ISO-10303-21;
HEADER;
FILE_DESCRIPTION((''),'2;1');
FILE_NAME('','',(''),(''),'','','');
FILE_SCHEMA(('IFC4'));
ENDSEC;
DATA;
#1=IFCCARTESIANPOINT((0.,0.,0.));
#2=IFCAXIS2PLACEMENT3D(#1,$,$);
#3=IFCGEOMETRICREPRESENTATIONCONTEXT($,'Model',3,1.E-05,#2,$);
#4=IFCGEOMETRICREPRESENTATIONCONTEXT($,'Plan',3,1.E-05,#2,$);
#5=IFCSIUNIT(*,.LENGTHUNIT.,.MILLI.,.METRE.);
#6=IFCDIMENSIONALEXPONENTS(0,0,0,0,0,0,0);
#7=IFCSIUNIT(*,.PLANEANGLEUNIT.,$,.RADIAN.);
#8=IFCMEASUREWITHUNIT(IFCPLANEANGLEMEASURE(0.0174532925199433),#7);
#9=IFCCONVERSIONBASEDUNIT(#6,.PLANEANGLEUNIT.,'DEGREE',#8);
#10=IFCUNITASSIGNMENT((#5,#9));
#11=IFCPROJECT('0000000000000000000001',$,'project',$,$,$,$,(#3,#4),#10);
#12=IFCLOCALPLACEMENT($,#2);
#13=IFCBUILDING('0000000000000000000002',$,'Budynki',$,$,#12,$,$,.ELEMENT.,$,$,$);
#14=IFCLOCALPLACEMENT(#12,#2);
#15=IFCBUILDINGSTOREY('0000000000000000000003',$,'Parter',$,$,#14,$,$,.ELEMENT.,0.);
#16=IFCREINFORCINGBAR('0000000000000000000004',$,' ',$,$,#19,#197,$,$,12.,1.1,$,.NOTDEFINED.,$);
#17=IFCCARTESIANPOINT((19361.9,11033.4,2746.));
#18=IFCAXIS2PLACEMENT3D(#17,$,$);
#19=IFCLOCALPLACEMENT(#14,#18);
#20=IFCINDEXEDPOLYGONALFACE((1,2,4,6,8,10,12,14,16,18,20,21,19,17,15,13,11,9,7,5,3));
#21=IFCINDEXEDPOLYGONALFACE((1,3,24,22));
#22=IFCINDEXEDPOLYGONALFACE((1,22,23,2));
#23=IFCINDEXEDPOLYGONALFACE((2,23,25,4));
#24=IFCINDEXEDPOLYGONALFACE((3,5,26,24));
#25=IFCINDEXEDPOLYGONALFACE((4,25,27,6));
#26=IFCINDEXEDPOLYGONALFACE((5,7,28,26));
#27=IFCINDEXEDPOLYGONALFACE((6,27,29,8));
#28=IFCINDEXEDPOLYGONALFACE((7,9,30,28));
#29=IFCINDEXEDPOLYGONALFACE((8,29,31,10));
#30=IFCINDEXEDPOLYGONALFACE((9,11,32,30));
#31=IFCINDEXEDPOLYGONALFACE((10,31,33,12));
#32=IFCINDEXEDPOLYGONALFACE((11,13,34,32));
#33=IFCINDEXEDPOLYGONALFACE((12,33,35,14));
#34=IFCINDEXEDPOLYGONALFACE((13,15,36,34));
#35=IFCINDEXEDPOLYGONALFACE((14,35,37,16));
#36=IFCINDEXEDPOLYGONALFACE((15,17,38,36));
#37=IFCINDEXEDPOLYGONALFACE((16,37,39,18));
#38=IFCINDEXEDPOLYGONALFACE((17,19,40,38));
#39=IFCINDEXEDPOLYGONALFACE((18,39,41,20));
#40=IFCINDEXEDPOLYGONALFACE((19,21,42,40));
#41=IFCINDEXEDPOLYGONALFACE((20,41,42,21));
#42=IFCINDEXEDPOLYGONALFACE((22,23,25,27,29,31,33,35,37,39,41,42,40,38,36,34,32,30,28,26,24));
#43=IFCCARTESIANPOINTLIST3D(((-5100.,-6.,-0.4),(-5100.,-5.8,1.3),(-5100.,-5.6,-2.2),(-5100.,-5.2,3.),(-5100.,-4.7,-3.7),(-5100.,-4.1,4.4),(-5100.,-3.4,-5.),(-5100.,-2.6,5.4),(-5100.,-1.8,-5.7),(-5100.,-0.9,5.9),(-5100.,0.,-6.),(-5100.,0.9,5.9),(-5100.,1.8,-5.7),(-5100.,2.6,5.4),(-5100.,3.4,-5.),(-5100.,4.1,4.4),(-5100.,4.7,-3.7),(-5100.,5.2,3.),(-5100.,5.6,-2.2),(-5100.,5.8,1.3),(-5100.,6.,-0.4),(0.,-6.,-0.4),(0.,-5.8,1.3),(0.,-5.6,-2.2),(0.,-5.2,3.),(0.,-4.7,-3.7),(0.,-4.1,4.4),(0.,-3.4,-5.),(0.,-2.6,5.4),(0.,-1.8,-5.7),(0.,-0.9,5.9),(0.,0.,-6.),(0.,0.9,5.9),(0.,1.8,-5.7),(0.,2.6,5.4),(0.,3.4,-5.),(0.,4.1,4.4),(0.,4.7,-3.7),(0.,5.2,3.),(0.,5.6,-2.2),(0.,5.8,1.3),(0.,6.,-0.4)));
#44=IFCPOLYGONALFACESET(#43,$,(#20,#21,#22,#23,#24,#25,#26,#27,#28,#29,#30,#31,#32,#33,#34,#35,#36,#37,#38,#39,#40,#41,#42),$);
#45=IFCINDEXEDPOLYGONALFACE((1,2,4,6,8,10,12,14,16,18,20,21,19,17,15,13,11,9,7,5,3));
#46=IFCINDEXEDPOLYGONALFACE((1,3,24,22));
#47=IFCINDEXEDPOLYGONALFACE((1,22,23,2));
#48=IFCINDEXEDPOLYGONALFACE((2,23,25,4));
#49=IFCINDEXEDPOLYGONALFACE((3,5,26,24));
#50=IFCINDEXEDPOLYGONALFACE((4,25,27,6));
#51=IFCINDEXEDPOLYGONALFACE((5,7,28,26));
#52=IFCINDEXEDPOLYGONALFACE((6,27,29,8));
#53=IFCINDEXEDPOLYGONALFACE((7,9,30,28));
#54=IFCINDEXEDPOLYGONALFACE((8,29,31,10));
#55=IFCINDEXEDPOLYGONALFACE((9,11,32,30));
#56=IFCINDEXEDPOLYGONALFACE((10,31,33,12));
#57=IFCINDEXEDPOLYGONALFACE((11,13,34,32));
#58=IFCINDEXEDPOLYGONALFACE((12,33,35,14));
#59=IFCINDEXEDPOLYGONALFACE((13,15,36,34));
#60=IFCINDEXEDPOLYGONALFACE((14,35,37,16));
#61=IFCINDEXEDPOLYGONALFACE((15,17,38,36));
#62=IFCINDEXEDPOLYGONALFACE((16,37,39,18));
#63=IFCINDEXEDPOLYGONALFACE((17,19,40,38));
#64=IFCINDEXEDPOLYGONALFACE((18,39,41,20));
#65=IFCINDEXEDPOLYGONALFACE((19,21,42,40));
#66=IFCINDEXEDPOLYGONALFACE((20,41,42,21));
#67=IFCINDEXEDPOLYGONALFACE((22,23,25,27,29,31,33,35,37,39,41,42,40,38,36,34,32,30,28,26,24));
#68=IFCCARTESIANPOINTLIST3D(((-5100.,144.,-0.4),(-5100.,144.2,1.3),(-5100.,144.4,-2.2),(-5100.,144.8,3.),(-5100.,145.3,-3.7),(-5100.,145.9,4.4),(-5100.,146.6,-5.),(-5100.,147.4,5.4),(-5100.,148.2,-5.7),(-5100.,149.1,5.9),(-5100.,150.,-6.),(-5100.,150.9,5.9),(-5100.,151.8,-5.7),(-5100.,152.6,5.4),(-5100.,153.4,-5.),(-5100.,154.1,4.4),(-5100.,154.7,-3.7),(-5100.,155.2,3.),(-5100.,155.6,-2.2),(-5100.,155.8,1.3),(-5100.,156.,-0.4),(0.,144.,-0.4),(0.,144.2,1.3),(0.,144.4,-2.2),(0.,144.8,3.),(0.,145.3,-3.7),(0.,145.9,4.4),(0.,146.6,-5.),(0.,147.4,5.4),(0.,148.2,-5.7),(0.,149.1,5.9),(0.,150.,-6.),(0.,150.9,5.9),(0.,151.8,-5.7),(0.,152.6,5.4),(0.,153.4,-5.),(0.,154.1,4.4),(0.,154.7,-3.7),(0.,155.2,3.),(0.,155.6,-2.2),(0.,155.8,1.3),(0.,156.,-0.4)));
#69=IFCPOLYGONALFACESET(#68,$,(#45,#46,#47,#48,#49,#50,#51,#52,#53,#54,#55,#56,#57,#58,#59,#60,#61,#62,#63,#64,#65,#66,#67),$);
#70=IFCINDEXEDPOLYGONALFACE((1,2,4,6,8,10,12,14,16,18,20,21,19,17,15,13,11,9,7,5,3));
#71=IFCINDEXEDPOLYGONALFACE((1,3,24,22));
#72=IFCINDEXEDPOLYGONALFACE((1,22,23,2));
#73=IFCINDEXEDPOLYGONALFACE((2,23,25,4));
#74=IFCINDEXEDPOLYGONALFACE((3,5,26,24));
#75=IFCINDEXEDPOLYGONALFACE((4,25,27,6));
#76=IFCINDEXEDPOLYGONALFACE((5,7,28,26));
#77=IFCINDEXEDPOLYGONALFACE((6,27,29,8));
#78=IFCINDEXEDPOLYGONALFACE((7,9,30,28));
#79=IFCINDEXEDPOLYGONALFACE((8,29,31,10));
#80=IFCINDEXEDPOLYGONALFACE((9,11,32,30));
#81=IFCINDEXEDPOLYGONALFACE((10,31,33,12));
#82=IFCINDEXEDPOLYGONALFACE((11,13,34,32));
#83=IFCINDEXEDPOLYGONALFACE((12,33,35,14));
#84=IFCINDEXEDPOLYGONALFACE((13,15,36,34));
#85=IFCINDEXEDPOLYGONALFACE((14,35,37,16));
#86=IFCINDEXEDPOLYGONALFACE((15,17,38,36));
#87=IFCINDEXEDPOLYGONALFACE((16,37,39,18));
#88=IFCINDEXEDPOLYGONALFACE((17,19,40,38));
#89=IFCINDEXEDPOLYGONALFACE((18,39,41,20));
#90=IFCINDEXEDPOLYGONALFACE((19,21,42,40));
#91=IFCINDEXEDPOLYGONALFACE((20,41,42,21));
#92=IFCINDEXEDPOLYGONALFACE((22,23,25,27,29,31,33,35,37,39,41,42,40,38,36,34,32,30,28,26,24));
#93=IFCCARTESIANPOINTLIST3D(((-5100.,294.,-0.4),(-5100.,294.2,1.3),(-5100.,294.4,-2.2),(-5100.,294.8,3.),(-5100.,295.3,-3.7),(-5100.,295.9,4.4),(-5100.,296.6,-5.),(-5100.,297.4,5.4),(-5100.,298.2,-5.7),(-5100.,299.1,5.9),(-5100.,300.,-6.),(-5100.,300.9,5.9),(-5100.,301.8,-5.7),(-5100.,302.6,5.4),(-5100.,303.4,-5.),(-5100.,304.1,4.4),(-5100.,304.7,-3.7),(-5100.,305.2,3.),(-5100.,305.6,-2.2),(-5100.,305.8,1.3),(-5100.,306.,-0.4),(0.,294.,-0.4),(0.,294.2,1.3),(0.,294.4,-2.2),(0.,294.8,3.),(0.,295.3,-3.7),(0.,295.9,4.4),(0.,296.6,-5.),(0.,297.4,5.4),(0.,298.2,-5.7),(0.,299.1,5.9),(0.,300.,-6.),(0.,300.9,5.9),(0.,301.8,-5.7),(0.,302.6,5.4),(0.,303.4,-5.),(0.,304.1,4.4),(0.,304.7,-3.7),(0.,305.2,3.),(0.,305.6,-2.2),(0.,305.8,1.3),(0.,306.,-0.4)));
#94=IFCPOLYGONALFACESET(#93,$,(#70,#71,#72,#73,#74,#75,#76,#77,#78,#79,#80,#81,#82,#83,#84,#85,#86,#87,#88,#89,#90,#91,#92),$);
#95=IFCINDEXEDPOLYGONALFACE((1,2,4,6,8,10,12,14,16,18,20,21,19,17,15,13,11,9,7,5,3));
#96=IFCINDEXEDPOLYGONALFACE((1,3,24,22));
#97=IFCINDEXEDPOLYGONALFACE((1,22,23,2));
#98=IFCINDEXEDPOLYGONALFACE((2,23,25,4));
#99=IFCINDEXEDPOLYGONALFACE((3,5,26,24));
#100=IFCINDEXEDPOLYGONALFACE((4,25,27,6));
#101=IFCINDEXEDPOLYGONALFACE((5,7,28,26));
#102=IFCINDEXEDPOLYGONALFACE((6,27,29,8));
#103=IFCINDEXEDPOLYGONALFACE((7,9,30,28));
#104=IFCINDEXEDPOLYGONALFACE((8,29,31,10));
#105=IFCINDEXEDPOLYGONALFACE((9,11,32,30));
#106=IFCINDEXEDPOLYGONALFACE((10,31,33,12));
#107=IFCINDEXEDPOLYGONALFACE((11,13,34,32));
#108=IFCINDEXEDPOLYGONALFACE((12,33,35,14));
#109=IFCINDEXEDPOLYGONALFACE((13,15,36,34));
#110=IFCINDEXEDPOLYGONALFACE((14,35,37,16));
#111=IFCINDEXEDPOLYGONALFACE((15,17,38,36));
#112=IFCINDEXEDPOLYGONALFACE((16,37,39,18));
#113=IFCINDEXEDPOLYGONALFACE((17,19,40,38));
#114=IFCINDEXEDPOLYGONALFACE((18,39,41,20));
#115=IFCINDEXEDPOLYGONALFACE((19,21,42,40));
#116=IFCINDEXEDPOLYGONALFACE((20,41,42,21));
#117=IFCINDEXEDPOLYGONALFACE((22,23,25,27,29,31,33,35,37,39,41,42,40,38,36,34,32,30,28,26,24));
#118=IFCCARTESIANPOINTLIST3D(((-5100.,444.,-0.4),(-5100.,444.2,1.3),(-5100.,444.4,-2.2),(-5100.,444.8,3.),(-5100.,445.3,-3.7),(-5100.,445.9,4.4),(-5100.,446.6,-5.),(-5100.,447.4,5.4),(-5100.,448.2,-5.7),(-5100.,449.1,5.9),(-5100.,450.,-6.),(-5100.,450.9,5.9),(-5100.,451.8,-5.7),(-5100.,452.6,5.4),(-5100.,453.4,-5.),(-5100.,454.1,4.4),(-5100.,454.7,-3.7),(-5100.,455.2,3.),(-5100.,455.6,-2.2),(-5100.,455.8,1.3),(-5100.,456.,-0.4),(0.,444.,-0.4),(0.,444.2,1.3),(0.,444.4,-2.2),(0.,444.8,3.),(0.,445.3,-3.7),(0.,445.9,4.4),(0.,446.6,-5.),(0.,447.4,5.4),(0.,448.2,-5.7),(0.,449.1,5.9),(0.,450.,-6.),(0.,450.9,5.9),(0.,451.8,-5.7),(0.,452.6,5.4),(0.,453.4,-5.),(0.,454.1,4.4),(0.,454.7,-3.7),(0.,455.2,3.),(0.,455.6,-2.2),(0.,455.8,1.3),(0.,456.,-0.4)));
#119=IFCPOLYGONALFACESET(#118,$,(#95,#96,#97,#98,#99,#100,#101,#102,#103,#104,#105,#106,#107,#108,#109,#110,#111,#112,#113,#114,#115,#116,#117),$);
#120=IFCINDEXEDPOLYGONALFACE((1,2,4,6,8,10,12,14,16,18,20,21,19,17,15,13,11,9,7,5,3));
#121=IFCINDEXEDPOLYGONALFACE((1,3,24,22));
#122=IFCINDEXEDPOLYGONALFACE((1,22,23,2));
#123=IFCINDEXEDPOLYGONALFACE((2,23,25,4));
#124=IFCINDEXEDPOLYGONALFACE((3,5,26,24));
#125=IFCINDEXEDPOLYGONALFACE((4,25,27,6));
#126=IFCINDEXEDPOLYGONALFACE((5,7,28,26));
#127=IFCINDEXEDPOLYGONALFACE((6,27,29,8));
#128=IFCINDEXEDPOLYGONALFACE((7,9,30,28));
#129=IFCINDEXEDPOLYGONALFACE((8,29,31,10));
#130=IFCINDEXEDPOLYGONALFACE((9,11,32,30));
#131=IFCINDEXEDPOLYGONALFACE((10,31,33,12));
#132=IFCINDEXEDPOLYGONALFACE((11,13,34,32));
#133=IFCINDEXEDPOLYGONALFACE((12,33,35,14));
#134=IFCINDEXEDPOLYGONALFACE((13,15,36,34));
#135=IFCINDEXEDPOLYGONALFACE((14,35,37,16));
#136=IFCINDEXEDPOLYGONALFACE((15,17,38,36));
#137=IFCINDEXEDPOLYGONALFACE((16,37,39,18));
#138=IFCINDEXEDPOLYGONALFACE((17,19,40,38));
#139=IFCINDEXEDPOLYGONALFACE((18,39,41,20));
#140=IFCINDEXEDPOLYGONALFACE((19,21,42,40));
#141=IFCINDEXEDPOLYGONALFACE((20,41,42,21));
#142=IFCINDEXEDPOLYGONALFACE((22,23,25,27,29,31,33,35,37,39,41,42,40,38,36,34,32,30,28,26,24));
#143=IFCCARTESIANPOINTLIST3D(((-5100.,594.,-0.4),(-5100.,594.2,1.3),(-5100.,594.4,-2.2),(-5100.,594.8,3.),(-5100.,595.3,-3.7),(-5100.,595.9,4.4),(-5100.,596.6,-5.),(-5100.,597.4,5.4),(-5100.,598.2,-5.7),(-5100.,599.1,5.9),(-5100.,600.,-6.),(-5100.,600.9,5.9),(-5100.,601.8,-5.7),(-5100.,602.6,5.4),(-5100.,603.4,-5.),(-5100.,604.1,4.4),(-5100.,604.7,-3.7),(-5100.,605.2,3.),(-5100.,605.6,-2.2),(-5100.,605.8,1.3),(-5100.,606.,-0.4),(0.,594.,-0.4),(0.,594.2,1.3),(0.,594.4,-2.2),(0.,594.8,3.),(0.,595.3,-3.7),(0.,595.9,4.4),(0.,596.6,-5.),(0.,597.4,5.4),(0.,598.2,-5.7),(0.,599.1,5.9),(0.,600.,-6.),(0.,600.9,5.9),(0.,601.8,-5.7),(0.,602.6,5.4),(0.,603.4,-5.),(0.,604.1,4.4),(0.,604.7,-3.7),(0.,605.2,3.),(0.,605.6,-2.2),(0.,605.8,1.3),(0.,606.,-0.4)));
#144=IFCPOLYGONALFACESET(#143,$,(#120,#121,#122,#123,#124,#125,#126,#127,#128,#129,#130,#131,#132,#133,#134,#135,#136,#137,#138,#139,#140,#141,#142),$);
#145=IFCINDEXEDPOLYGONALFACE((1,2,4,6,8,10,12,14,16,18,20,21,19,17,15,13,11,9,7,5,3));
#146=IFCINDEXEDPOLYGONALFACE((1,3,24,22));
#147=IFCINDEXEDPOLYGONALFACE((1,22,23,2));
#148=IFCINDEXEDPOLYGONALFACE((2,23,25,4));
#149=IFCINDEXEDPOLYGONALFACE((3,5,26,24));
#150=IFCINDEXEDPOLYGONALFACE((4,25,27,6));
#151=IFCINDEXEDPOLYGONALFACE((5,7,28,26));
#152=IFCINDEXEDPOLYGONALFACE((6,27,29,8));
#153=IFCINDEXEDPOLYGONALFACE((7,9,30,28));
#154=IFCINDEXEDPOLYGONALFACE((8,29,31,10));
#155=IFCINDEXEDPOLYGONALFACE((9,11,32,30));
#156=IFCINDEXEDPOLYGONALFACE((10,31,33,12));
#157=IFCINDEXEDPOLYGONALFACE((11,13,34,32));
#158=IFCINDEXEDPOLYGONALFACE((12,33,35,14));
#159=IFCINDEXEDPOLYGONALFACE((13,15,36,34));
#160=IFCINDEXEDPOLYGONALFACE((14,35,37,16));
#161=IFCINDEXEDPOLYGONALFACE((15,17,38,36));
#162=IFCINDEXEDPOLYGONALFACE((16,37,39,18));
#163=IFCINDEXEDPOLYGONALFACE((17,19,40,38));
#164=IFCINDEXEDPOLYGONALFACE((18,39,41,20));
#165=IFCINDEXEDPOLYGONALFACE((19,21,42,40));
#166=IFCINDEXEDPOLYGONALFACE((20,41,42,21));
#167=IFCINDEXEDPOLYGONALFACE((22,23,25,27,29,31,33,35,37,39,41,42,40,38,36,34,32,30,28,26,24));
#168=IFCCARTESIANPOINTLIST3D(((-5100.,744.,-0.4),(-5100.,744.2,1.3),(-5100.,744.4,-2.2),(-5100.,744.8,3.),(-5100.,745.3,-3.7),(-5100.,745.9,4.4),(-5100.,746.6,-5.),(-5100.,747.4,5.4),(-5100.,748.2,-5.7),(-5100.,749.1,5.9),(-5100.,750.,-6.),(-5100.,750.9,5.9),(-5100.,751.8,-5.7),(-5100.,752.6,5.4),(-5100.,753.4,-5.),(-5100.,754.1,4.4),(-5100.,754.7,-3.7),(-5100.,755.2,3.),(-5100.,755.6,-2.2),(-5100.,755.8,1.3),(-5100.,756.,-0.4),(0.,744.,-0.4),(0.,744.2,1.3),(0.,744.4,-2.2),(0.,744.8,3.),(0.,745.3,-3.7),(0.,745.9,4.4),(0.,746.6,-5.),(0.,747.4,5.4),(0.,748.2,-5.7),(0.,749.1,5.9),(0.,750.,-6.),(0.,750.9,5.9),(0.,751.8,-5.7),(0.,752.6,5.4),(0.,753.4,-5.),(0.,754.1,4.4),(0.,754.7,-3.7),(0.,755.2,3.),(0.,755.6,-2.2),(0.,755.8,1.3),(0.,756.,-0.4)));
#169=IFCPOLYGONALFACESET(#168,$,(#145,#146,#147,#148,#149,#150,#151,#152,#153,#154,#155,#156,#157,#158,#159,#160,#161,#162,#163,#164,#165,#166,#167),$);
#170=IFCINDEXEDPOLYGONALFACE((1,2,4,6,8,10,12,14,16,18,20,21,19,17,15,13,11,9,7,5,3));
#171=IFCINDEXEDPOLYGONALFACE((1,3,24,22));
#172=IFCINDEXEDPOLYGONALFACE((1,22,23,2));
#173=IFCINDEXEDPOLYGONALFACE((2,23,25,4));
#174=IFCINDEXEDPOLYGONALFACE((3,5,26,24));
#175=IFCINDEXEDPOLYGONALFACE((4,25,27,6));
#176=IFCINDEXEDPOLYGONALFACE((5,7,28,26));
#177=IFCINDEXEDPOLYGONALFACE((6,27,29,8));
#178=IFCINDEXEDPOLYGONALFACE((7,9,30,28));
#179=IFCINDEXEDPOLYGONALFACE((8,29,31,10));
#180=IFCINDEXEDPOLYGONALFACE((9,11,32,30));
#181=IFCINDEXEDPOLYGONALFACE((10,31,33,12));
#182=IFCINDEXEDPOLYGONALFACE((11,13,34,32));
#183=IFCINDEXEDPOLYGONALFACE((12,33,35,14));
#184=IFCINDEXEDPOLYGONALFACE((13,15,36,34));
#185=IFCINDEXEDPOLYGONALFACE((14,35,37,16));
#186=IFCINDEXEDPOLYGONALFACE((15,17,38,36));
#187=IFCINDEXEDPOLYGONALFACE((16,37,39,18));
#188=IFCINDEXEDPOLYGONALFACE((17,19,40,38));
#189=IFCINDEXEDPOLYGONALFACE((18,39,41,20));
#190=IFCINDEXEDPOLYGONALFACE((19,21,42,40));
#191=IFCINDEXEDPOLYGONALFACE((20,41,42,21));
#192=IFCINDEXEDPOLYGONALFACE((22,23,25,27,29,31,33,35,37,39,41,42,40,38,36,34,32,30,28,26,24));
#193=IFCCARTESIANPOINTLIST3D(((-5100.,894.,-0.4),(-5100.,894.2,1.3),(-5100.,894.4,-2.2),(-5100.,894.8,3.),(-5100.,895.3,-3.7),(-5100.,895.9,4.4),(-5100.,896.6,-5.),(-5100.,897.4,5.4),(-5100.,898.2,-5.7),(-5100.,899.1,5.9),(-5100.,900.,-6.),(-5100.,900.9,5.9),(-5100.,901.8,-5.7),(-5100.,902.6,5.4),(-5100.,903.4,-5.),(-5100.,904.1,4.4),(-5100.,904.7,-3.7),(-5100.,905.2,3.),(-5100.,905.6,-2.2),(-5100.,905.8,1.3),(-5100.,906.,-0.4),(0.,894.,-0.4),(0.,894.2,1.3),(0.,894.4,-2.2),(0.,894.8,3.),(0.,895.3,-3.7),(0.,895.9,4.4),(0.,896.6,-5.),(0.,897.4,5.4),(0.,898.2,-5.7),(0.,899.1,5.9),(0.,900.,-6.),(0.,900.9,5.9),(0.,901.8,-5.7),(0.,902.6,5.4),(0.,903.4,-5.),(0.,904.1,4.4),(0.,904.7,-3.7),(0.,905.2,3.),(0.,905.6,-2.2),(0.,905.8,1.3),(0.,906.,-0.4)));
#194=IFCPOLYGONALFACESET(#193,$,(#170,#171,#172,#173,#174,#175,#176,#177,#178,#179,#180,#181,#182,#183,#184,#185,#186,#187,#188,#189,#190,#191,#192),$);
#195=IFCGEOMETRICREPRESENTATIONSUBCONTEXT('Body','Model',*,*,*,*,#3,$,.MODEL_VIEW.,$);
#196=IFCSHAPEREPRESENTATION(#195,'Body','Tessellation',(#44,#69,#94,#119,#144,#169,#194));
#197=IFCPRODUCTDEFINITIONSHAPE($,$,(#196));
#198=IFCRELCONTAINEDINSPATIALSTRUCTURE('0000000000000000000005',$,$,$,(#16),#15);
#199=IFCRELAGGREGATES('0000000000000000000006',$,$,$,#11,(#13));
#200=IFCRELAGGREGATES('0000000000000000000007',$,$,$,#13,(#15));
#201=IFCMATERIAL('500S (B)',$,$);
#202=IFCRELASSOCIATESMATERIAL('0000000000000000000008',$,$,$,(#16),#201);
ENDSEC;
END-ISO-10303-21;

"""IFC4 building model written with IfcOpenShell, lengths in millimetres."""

from ifc_helpers import new_model, entity, si_unit, converted_unit, frame, origin, place, context, subcontext, project, spatial, material, element, save


model = new_model("IFC4")

# Units and contexts
model_context = context("Model", 3, precision=1e-05, world=origin())
plan_context = context("Plan", 3, precision=1e-05, world=origin())
body_context = subcontext(model_context, "Body", "Model", "MODEL_VIEW")
ifc_project = project(units=[si_unit("LENGTHUNIT", "METRE", prefix="MILLI"), converted_unit("PLANEANGLEUNIT", "DEGREE", entity("IfcPlaneAngleMeasure", 0.0174532925199433), si_unit("PLANEANGLEUNIT", "RADIAN"), dimensions=[0, 0, 0, 0, 0, 0, 0])], contexts=[model_context, plan_context])

# Building, storey
building_placement = place(None, origin())
building = spatial("IfcBuilding", under=ifc_project, at=building_placement, Name="Budynki", CompositionType="ELEMENT")
storey_placement = place(building_placement, origin())
storey = spatial("IfcBuildingStorey", under=building, at=storey_placement, Name="Parter", CompositionType="ELEMENT", Elevation=0.0)

# Reinforcing bar
ifc_material_1 = material(Name="500S (B)")
reinforcing_bar_1_placement = place(storey_placement, frame((19361.9, 11033.4, 2746.0)))
element("IfcReinforcingBar", 1, at=reinforcing_bar_1_placement, inside=storey, material=ifc_material_1, Name=" ", CrossSectionArea=1.1, NominalDiameter=12.0, PredefinedType="NOTDEFINED", context=body_context, shape_type="AdvancedSweptSolid", body=[
    entity("IfcSweptDiskSolid", entity("IfcPolyline", [entity("IfcCartesianPoint", [0.0, 0.0, 0.0]), entity("IfcCartesianPoint", [-5100.0, 0.0, 0.0])]), 6.0, None, 0.0, 1.0),
    entity("IfcSweptDiskSolid", entity("IfcPolyline", [entity("IfcCartesianPoint", [0.0, 150.0, 0.0]), entity("IfcCartesianPoint", [-5100.0, 150.0, 0.0])]), 6.0, None, 0.0, 1.0),
    entity("IfcSweptDiskSolid", entity("IfcPolyline", [entity("IfcCartesianPoint", [0.0, 300.0, 0.0]), entity("IfcCartesianPoint", [-5100.0, 300.0, 0.0])]), 6.0, None, 0.0, 1.0),
    entity("IfcSweptDiskSolid", entity("IfcPolyline", [entity("IfcCartesianPoint", [0.0, 450.0, 0.0]), entity("IfcCartesianPoint", [-5100.0, 450.0, 0.0])]), 6.0, None, 0.0, 1.0),
    entity("IfcSweptDiskSolid", entity("IfcPolyline", [entity("IfcCartesianPoint", [0.0, 600.0, 0.0]), entity("IfcCartesianPoint", [-5100.0, 600.0, 0.0])]), 6.0, None, 0.0, 1.0),
    entity("IfcSweptDiskSolid", entity("IfcPolyline", [entity("IfcCartesianPoint", [0.0, 750.0, 0.0]), entity("IfcCartesianPoint", [-5100.0, 750.0, 0.0])]), 6.0, None, 0.0, 1.0),
    entity("IfcSweptDiskSolid", entity("IfcPolyline", [entity("IfcCartesianPoint", [0.0, 900.0, 0.0]), entity("IfcCartesianPoint", [-5100.0, 900.0, 0.0])]), 6.0, None, 0.0, 1.0),
])

save(model, "model.ifc")
